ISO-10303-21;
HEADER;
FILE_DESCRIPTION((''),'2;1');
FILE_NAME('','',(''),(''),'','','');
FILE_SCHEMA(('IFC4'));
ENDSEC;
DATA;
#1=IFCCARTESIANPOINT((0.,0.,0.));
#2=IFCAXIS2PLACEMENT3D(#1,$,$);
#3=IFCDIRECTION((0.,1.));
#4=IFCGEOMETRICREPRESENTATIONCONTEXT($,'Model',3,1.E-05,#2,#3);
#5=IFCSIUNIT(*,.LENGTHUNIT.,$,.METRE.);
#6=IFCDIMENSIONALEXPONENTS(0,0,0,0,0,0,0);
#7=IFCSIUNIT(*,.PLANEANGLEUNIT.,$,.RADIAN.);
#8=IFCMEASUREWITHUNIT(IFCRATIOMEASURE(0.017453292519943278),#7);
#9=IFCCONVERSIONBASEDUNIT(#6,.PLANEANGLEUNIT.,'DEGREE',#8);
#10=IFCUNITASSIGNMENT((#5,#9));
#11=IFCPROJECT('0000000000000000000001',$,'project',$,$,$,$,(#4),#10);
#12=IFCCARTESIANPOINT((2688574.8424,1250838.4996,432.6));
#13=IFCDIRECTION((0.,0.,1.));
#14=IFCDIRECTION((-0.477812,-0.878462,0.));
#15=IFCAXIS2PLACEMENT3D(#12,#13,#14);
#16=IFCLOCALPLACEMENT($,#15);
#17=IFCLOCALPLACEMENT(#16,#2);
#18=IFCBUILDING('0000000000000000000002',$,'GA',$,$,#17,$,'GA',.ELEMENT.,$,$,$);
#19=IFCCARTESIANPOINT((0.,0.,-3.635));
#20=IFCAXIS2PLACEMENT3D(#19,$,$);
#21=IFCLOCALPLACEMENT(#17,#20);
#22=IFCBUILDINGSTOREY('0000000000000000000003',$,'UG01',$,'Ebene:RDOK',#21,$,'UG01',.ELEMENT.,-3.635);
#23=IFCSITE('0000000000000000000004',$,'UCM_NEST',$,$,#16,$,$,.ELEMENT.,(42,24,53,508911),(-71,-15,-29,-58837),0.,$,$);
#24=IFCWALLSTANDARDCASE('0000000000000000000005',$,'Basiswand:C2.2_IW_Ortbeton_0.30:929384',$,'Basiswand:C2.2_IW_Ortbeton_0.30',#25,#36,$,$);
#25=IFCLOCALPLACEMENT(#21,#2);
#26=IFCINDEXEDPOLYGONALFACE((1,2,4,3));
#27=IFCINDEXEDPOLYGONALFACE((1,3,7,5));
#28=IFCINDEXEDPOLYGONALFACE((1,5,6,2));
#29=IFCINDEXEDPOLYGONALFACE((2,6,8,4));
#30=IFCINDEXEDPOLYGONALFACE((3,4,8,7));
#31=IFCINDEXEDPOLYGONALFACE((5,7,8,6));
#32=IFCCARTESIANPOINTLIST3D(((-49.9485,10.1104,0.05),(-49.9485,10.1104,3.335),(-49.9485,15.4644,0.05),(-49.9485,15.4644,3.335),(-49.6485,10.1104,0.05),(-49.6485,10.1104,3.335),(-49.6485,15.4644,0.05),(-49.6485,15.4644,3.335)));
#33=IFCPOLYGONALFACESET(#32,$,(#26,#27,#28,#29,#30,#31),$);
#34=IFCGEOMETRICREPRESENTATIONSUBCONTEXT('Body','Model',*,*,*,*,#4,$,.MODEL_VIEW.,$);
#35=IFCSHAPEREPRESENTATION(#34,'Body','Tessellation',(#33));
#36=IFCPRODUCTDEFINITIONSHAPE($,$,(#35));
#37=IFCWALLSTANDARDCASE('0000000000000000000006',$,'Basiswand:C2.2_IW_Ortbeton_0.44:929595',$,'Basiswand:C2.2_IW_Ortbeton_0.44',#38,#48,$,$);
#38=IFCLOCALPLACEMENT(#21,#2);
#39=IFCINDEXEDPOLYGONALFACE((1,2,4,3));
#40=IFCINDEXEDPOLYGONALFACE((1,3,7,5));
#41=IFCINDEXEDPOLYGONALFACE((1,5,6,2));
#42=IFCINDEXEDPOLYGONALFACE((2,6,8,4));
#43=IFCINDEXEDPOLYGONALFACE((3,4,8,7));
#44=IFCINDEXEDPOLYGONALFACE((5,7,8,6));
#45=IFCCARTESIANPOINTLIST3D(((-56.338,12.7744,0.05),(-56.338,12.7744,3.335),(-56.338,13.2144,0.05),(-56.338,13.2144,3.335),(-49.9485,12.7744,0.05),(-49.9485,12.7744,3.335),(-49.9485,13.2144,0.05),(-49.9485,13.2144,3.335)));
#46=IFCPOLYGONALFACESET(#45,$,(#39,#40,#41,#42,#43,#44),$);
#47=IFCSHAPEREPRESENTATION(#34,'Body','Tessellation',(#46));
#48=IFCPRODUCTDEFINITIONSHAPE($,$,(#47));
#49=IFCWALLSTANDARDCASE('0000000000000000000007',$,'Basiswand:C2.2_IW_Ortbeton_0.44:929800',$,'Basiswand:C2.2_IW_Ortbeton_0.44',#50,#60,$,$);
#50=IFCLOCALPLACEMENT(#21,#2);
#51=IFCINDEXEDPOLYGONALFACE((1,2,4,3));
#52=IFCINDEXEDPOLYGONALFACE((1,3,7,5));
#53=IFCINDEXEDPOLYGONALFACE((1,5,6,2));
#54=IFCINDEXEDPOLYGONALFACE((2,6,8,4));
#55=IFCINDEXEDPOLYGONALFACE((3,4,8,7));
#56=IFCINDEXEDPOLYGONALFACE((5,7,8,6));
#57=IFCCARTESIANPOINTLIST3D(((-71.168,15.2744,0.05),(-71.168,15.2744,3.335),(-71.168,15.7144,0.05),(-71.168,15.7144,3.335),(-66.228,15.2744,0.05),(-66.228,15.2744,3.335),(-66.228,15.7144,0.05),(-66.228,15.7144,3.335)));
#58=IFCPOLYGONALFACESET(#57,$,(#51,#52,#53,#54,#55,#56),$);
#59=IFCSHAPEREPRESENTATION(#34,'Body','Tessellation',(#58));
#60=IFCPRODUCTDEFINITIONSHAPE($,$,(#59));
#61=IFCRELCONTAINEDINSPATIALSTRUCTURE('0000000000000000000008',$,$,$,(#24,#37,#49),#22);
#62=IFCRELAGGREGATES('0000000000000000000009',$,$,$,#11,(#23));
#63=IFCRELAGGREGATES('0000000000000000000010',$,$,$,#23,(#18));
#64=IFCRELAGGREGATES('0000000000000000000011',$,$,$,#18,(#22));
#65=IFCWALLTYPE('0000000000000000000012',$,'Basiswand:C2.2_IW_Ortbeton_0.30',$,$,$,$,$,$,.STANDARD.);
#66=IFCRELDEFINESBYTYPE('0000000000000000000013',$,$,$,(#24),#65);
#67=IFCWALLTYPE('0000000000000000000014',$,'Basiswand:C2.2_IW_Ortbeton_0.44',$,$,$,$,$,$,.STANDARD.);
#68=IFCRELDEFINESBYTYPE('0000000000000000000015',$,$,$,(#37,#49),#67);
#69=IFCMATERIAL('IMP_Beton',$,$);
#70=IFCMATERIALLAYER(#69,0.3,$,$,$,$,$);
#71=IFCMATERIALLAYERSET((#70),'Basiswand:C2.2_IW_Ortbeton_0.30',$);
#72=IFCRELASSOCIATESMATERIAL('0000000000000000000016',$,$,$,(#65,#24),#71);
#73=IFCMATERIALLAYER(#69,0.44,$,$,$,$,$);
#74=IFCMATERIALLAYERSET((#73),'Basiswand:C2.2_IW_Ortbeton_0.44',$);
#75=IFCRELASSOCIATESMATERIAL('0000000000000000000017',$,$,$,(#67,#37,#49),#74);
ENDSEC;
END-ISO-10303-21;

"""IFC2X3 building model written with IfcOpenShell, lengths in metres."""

from ifc_helpers import new_model, entity, si_unit, converted_unit, direction, frame, frame_2d, origin, place, context, subcontext, project, spatial, polyline, rectangle, extrude, clip, bounded_halfspace, material, layer, layer_set, layer_usage, type_object, element, save


model = new_model("IFC2X3")

# Units and contexts
model_context = context("Model", 3, precision=1e-05, world=origin(), true_north=direction((0.0, 1.0)))
body_context = subcontext(model_context, "Body", "Model", "MODEL_VIEW")
ifc_project = project(units=[si_unit("LENGTHUNIT", "METRE"), converted_unit("PLANEANGLEUNIT", "DEGREE", entity("IfcRatioMeasure", 0.017453292519943278), si_unit("PLANEANGLEUNIT", "RADIAN"), dimensions=[0, 0, 0, 0, 0, 0, 0])], contexts=[model_context])

# Site, building, storey
site_placement = place(None, frame((2688574.8424, 1250838.4996, 432.6), z_axis=(0.0, 0.0, 1.0), x_axis=(-0.477812, -0.878462, 0.0)))
site = spatial("IfcSite", under=ifc_project, at=site_placement, Name="UCM_NEST", CompositionType="ELEMENT", RefLatitude=(42, 24, 53, 508911), RefLongitude=(-71, -15, -29, -58837), RefElevation=0.0)
building_placement = place(site_placement, origin())
building = spatial("IfcBuilding", under=site, at=building_placement, Name="GA", LongName="GA", CompositionType="ELEMENT")
storey_placement = place(building_placement, frame((0.0, 0.0, -3.635)))
storey = spatial("IfcBuildingStorey", under=building, at=storey_placement, Name="UG01", ObjectType="Ebene:RDOK", LongName="UG01", CompositionType="ELEMENT", Elevation=-3.635)

# Walls
ifc_material_1 = material(Name="IMP_Beton")
ifc_layer_1 = layer(ifc_material_1, 0.3)
ifc_layer_set_1 = layer_set([ifc_layer_1], Name="Basiswand:C2.2_IW_Ortbeton_0.30")
ifc_layer_usage_1 = layer_usage(ifc_layer_set_1, "AXIS2", "NEGATIVE", 0.15)
wall_type_1 = type_object("IfcWallType", Name="Basiswand:C2.2_IW_Ortbeton_0.30", PredefinedType="STANDARD", material=ifc_layer_set_1)
wall_1_placement = place(storey_placement, frame((-49.7985, 15.4644, 0.05), z_axis=(0.0, 0.0, 1.0), x_axis=(0.0, -1.0, 0.0)))
element("IfcWallStandardCase", 1, at=wall_1_placement, inside=storey, type_object=wall_type_1, material=ifc_layer_usage_1, Name="Basiswand:C2.2_IW_Ortbeton_0.30:929384", ObjectType="Basiswand:C2.2_IW_Ortbeton_0.30", context=body_context, shape_type="Clipping", body=[
    clip(extrude(rectangle(XDim=5.354, YDim=0.3, at=frame_2d((2.677, 0.0), x_axis=(-1.0, 0.0))), origin(), (0.0, 0.0, 1.0), 3.285), bounded_halfspace(frame((5.354, -0.15, 0.0), z_axis=(0.0, 0.0, 1.0), x_axis=(-1.0, 0.0, 0.0)), True, frame((5.354, -0.15, 0.0), z_axis=(0.0, 0.0, 1.0), x_axis=(-1.0, 0.0, 0.0)), polyline([(0.0, 0.0), (0.0, -0.3), (5.354, -0.3), (5.354, 0.0), (3.104, 0.0), (2.664, 0.0), (0.0, 0.0)]))),
])
ifc_layer_2 = layer(ifc_material_1, 0.44)
ifc_layer_set_2 = layer_set([ifc_layer_2], Name="Basiswand:C2.2_IW_Ortbeton_0.44")
ifc_layer_usage_2 = layer_usage(ifc_layer_set_2, "AXIS2", "NEGATIVE", 0.22)
wall_type_2 = type_object("IfcWallType", Name="Basiswand:C2.2_IW_Ortbeton_0.44", PredefinedType="STANDARD", material=ifc_layer_set_2)
wall_2_placement = place(storey_placement, frame((-49.9485, 12.9944, 0.05), z_axis=(0.0, 0.0, 1.0), x_axis=(-1.0, 0.0, 0.0)))
element("IfcWallStandardCase", 2, at=wall_2_placement, inside=storey, type_object=wall_type_2, material=ifc_layer_usage_2, Name="Basiswand:C2.2_IW_Ortbeton_0.44:929595", ObjectType="Basiswand:C2.2_IW_Ortbeton_0.44", context=body_context, shape_type="Clipping", body=[
    clip(extrude(rectangle(XDim=6.3895, YDim=0.44, at=frame_2d((3.1947, 0.0), x_axis=(-1.0, 0.0))), origin(), (0.0, 0.0, 1.0), 3.285), bounded_halfspace(frame((6.3895, -0.22, 0.0), z_axis=(0.0, 0.0, 1.0), x_axis=(0.0, -1.0, 0.0)), True, frame((6.3895, -0.22, 0.0), z_axis=(0.0, 0.0, 1.0), x_axis=(0.0, -1.0, 0.0)), polyline([(0.0, 0.0), (-0.44, 0.0), (-0.44, -6.3895), (0.0, -6.3895), (0.0, 0.0)]))),
])
wall_3_placement = place(storey_placement, frame((-66.228, 15.4944, 0.05), z_axis=(0.0, 0.0, 1.0), x_axis=(-1.0, 0.0, 0.0)))
element("IfcWallStandardCase", 3, at=wall_3_placement, inside=storey, type_object=wall_type_2, material=ifc_layer_usage_2, Name="Basiswand:C2.2_IW_Ortbeton_0.44:929800", ObjectType="Basiswand:C2.2_IW_Ortbeton_0.44", context=body_context, shape_type="Clipping", body=[
    clip(extrude(rectangle(XDim=4.94, YDim=0.44, at=frame_2d((2.47, 0.0), x_axis=(-1.0, 0.0))), origin(), (0.0, 0.0, 1.0), 3.285), bounded_halfspace(frame((4.94, -0.22, 0.0), z_axis=(0.0, 0.0, 1.0), x_axis=(0.0, -1.0, 0.0)), True, frame((4.94, -0.22, 0.0), z_axis=(0.0, 0.0, 1.0), x_axis=(0.0, -1.0, 0.0)), polyline([(0.0, 0.0), (-0.44, 0.0), (-0.44, -4.94), (-0.25, -4.94), (0.0, -4.94), (0.0, 0.0)]))),
])

save(model, "model.ifc")
